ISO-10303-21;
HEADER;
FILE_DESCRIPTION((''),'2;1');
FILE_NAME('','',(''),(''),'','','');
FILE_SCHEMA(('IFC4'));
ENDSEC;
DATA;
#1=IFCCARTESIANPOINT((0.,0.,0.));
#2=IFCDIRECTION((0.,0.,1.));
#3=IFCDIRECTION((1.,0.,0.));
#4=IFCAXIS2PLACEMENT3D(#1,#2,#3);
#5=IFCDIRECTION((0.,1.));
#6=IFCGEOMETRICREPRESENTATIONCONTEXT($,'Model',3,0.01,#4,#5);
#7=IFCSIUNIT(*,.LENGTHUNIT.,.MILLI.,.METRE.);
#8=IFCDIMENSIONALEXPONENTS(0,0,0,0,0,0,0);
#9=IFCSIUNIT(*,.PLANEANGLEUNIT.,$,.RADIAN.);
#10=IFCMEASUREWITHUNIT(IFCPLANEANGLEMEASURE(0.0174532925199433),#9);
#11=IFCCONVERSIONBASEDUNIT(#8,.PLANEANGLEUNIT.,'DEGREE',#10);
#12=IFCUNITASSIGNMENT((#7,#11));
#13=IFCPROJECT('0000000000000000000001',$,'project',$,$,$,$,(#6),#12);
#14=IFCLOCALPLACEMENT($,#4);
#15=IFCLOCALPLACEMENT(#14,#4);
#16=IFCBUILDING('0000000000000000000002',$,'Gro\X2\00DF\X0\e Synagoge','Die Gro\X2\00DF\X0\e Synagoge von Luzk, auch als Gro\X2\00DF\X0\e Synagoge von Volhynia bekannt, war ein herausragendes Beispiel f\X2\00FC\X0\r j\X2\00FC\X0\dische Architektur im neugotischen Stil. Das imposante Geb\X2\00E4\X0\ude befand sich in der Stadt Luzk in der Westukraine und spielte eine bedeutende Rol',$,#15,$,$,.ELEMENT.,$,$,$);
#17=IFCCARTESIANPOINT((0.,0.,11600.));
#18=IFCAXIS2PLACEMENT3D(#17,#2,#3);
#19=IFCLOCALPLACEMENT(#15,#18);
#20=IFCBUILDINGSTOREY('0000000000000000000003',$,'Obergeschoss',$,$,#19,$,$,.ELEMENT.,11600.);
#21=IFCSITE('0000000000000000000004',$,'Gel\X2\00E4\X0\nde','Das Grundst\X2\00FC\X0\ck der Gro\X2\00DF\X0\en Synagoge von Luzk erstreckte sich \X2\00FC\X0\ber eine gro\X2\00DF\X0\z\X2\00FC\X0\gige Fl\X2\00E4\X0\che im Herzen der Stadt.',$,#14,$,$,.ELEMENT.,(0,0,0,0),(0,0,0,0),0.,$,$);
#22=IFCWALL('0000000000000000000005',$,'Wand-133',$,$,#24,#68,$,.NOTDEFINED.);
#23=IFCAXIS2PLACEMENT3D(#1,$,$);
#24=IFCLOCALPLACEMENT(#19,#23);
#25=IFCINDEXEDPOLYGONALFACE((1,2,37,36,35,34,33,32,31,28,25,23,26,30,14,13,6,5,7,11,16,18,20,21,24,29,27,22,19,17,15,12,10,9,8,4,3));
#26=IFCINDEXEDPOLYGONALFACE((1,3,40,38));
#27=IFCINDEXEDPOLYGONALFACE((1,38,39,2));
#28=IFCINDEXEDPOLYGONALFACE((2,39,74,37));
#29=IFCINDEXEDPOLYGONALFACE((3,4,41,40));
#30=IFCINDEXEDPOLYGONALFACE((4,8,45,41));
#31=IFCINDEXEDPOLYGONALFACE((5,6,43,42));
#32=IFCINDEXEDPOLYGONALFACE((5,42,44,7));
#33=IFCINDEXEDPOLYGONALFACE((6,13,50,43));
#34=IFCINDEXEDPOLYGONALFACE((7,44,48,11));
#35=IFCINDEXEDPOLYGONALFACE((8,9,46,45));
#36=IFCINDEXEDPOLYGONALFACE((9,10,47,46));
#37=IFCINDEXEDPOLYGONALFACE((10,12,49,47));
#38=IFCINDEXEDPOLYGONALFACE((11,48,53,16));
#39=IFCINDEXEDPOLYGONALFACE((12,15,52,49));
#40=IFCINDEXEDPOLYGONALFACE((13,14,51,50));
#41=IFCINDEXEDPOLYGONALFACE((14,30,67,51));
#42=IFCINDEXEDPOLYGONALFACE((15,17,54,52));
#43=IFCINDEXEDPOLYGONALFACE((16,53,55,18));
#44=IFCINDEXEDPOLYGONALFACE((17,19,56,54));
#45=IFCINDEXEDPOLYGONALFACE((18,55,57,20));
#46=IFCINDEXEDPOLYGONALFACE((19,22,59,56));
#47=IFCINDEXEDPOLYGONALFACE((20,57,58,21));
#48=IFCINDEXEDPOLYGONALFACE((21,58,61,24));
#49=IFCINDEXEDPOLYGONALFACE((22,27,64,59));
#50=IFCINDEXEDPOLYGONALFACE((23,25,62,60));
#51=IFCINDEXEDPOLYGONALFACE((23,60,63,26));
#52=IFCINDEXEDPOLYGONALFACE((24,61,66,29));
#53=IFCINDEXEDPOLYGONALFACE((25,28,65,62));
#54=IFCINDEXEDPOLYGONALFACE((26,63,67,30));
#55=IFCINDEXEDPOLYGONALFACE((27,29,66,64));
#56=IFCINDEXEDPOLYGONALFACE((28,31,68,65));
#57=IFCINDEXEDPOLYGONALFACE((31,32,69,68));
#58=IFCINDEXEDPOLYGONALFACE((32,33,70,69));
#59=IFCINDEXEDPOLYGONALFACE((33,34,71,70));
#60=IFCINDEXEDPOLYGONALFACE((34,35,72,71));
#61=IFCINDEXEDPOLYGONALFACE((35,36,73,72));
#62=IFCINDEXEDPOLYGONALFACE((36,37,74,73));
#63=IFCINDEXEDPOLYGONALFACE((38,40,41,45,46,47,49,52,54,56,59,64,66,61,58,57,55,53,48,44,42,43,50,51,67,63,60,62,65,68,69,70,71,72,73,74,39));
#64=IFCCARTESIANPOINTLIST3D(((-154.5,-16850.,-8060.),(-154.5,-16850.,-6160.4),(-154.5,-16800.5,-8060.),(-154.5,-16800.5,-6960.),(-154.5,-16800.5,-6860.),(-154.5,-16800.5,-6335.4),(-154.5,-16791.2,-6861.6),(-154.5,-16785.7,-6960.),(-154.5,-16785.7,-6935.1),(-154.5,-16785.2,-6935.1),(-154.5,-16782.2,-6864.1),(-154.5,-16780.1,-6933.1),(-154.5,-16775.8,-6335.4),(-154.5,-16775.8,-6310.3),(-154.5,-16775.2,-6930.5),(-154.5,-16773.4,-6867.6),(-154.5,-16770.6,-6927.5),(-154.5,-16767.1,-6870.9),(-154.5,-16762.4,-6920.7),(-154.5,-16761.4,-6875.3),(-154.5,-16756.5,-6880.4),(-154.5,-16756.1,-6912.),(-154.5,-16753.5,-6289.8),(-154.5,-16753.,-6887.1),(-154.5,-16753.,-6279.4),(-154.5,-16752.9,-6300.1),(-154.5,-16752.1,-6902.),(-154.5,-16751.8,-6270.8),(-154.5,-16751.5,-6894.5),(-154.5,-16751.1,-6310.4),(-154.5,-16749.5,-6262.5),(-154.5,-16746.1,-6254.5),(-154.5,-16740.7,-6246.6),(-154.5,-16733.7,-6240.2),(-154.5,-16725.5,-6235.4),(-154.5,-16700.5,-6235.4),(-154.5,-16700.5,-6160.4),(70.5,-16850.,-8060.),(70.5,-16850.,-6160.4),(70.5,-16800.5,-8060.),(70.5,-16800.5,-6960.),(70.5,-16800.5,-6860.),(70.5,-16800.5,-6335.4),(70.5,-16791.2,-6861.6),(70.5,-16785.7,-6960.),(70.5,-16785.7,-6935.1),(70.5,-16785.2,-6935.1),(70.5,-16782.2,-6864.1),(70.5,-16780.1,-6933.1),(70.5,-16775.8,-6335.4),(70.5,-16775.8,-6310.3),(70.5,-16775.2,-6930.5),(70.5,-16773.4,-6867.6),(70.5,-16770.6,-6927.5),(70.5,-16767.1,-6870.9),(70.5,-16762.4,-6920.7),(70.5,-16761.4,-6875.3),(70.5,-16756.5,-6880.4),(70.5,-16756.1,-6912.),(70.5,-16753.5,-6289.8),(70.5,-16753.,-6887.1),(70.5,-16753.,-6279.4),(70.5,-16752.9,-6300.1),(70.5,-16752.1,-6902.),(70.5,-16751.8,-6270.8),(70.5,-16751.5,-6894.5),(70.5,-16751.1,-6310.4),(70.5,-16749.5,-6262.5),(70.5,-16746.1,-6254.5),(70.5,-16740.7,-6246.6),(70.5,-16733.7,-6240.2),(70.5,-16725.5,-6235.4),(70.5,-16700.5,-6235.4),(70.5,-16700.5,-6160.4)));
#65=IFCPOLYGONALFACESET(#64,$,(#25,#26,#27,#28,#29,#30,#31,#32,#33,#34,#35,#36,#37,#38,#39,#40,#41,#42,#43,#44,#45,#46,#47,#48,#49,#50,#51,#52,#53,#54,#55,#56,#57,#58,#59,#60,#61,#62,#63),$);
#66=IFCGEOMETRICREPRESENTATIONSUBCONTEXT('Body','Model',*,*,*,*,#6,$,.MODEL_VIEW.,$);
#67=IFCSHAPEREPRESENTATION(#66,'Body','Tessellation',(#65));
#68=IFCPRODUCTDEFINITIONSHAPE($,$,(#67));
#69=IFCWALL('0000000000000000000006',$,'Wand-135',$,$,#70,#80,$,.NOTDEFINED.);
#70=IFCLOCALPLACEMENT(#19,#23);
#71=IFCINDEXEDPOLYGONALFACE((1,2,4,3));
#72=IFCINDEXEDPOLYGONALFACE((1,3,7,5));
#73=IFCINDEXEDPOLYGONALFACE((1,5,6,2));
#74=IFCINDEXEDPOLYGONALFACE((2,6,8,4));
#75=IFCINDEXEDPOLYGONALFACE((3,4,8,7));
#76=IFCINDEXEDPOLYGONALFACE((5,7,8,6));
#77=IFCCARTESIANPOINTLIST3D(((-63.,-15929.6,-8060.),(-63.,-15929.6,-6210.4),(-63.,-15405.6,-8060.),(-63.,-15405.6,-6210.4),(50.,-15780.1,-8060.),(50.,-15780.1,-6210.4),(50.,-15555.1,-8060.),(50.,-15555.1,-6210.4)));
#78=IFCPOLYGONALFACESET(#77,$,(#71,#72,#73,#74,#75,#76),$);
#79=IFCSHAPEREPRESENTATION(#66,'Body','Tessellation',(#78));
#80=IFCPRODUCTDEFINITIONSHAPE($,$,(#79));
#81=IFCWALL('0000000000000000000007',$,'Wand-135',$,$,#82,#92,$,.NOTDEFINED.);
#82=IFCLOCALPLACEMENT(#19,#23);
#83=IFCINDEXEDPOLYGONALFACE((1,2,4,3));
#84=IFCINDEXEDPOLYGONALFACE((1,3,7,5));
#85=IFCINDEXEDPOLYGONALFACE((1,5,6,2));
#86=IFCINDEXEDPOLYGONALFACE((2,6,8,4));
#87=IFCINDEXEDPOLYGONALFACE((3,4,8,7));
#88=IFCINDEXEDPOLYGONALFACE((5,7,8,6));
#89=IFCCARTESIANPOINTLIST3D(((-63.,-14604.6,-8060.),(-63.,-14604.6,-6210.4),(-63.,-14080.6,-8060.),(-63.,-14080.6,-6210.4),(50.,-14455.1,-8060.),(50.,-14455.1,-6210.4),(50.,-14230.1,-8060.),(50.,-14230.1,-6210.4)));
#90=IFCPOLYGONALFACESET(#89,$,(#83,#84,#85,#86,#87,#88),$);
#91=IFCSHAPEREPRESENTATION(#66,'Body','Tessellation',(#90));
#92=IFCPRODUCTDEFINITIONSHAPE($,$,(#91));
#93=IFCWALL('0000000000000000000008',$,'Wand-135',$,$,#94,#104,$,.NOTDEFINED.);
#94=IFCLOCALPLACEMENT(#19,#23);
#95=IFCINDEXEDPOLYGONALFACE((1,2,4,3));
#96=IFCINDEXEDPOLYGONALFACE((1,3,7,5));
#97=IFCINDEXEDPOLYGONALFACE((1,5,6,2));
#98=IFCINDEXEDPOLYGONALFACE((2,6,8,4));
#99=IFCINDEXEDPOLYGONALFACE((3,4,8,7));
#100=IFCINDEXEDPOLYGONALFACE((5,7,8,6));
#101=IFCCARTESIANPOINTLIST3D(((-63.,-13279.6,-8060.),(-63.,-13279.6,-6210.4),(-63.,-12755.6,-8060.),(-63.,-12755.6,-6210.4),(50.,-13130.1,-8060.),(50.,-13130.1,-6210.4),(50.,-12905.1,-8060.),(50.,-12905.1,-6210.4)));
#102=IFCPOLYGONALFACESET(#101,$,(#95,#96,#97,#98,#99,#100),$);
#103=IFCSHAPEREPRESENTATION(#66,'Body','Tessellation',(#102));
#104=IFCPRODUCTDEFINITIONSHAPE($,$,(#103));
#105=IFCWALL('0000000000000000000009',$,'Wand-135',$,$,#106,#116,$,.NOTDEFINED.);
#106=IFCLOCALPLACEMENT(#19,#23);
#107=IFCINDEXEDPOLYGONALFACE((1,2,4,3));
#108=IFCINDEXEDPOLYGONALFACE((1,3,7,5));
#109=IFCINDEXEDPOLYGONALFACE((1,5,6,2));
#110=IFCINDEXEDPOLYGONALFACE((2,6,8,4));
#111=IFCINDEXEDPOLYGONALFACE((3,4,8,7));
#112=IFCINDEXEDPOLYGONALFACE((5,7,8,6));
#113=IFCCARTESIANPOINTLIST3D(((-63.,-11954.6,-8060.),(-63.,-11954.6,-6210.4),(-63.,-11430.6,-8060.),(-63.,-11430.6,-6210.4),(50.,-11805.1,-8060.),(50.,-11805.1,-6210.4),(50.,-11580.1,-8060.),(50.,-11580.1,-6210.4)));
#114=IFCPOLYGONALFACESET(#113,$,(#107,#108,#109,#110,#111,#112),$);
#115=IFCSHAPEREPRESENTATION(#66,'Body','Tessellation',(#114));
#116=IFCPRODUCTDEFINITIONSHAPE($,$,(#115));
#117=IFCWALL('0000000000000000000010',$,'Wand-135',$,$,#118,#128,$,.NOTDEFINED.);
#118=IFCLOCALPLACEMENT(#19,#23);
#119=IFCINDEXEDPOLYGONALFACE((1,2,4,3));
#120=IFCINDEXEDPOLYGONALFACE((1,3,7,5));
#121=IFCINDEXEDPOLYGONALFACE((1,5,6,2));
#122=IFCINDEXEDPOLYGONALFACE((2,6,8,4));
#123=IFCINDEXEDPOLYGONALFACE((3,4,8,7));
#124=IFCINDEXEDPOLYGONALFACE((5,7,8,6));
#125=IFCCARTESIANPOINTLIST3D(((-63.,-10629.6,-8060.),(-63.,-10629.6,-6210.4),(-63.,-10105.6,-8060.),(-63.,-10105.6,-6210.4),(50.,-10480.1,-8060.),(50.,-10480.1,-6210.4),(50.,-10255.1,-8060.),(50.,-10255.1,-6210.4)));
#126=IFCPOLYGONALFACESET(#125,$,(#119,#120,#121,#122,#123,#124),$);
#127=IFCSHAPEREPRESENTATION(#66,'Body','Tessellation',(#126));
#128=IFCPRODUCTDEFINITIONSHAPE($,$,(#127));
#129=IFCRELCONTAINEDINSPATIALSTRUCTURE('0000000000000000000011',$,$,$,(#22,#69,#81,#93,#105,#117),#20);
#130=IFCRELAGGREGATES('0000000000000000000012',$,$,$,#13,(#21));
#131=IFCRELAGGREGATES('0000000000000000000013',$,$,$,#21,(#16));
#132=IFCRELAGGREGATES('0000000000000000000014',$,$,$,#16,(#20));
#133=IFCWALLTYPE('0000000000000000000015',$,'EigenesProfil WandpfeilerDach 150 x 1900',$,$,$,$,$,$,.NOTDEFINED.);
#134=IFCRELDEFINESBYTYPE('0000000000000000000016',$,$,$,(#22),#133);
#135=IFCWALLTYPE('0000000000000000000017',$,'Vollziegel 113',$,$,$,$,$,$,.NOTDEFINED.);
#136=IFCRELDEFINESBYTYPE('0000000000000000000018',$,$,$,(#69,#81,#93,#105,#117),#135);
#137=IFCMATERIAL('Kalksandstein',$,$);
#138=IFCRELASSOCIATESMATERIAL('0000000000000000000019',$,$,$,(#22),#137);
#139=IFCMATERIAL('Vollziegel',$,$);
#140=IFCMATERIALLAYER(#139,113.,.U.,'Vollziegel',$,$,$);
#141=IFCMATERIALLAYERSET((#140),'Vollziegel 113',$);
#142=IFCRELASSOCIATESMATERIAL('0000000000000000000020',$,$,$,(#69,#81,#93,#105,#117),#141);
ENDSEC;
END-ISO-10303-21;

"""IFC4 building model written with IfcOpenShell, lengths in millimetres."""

from ifc_helpers import new_model, entity, si_unit, converted_unit, direction, frame, origin_with_axes, place, context, subcontext, project, spatial, line, arc, indexed_curve, outline, extrude, material, layer, layer_set, layer_usage, material_profile, profile_set, type_object, element, save


model = new_model("IFC4")

# Units and contexts
model_context = context("Model", 3, precision=0.01, world=origin_with_axes(), true_north=direction((0.0, 1.0)))
body_context = subcontext(model_context, "Body", "Model", "MODEL_VIEW")
ifc_project = project(units=[si_unit("LENGTHUNIT", "METRE", prefix="MILLI"), converted_unit("PLANEANGLEUNIT", "DEGREE", entity("IfcPlaneAngleMeasure", 0.0174532925199433), si_unit("PLANEANGLEUNIT", "RADIAN"), dimensions=[0, 0, 0, 0, 0, 0, 0])], contexts=[model_context])

# Site, building, storey
site_placement = place(None, origin_with_axes())
site = spatial("IfcSite", under=ifc_project, at=site_placement, Name="Gelände", Description="Das Grundstück der Großen Synagoge von Luzk erstreckte sich über eine großzügige Fläche im Herzen der Stadt.", CompositionType="ELEMENT", RefLatitude=(0, 0, 0, 0), RefLongitude=(0, 0, 0, 0), RefElevation=0.0)
building_placement = place(site_placement, origin_with_axes())
building = spatial("IfcBuilding", under=site, at=building_placement, Name="Große Synagoge", Description="Die Große Synagoge von Luzk, auch als Große Synagoge von Volhynia bekannt, war ein herausragendes Beispiel für jüdische Architektur im neugotischen Stil. Das imposante Gebäude befand sich in der Stadt Luzk in der Westukraine und spielte eine bedeutende Rol", CompositionType="ELEMENT")
storey_placement = place(building_placement, frame((0.0, 0.0, 11600.0), z_axis=(0.0, 0.0, 1.0), x_axis=(1.0, 0.0, 0.0)))
storey = spatial("IfcBuildingStorey", under=building, at=storey_placement, Name="Obergeschoss", CompositionType="ELEMENT", Elevation=11600.0)

# Walls
ifc_material_1 = material(Name="Kalksandstein")
ifc_material_profile = material_profile(ifc_material_1, outline(indexed_curve([(74.2, 1749.6), (98.9, 1749.6), (96.7, 1765.0), (97.0, 1780.5), (99.2, 1793.4), (103.9, 1805.5), (112.6, 1816.7), (124.5, 1824.6), (149.5, 1824.6), (149.5, 1899.6), (0.0, 1899.6), (0.0, 0.0), (49.5, 0.0), (49.5, 1100.0), (64.3, 1100.0), (64.3, 1124.9), (64.8, 1124.9), (72.4, 1128.1), (79.4, 1132.4), (91.1, 1143.4), (97.9, 1157.9), (98.0, 1169.2), (93.5, 1179.5), (85.8, 1187.0), (76.6, 1192.3), (63.3, 1197.2), (49.5, 1200.0), (49.5, 1724.6), (74.2, 1724.6)], segments=[line(1, 2), arc(2, 3, 4), arc(4, 5, 6), arc(6, 7, 8), line(8, 9, 10, 11, 12, 13, 14, 15, 16, 17), arc(17, 18, 19), arc(19, 20, 21), arc(21, 22, 23), arc(23, 24, 25), arc(25, 26, 27), line(27, 28, 29, 1)])), Name="Kalksandstein")
ifc_profile_set = profile_set([ifc_material_profile], Name="EigenesProfil WandpfeilerDach")
wall_type_1 = type_object("IfcWallType", Name="EigenesProfil WandpfeilerDach 150 x 1900", PredefinedType="NOTDEFINED")
wall_1_placement = place(storey_placement, frame((-154.5, -16850.0, -8060.0), z_axis=(0.0, 0.0, 1.0), x_axis=(1.0, 0.0, 0.0)))
element("IfcWall", 1, at=wall_1_placement, inside=storey, type_object=wall_type_1, material=ifc_profile_set, Name="Wand-133", PredefinedType="NOTDEFINED", context=body_context, shape_type="SweptSolid", body=[
    extrude(outline(indexed_curve([(74.2, 1749.6), (98.9, 1749.6), (96.7, 1765.0), (97.0, 1780.5), (99.2, 1793.4), (103.9, 1805.5), (112.6, 1816.7), (124.5, 1824.6), (149.5, 1824.6), (149.5, 1899.6), (0.0, 1899.6), (0.0, 0.0), (49.5, 0.0), (49.5, 1100.0), (64.3, 1100.0), (64.3, 1124.9), (64.8, 1124.9), (72.4, 1128.1), (79.4, 1132.4), (91.1, 1143.4), (97.9, 1157.9), (98.0, 1169.2), (93.5, 1179.5), (85.8, 1187.0), (76.6, 1192.3), (63.3, 1197.2), (49.5, 1200.0), (49.5, 1724.6), (74.2, 1724.6)], segments=[line(1, 2), arc(2, 3, 4), arc(4, 5, 6), arc(6, 7, 8), line(8, 9, 10, 11, 12, 13, 14, 15, 16, 17), arc(17, 18, 19), arc(19, 20, 21), arc(21, 22, 23), arc(23, 24, 25), arc(25, 26, 27), line(27, 28, 29, 1)])), frame((0.0, 0.0, 0.0), z_axis=(1.0, 0.0, 0.0), x_axis=(0.0, 1.0, 0.0)), (0.0, 0.0, 1.0), 225.0),
])
ifc_material_2 = material(Name="Vollziegel")
ifc_layer = layer(ifc_material_2, 113.0, ventilated="UNKNOWN", Name="Vollziegel")
ifc_layer_set = layer_set([ifc_layer], Name="Vollziegel 113")
ifc_layer_usage_1 = layer_usage(ifc_layer_set, "AXIS2", "NEGATIVE", 113.0)
wall_type_2 = type_object("IfcWallType", Name="Vollziegel 113", PredefinedType="NOTDEFINED")
wall_2_placement = place(storey_placement, frame((-63.0, -15555.1, -8060.0), z_axis=(0.0, 0.0, 1.0), x_axis=(0.0, -1.0, 0.0)))
element("IfcWall", 2, at=wall_2_placement, inside=storey, type_object=wall_type_2, material=ifc_layer_usage_1, Name="Wand-135", PredefinedType="NOTDEFINED", context=body_context, shape_type="SweptSolid", body=[
    extrude(outline(indexed_curve([(-149.5, 0.0), (374.5, 0.0), (225.0, 113.0), (0.0, 113.0)], segments=[line(1, 2, 3, 4, 1)])), origin_with_axes(), (0.0, 0.0, 1.0), 1849.6),
])
ifc_layer_usage_2 = layer_usage(ifc_layer_set, "AXIS2", "NEGATIVE", 113.0)
wall_3_placement = place(storey_placement, frame((-63.0, -14230.1, -8060.0), z_axis=(0.0, 0.0, 1.0), x_axis=(0.0, -1.0, 0.0)))
element("IfcWall", 3, at=wall_3_placement, inside=storey, type_object=wall_type_2, material=ifc_layer_usage_2, Name="Wand-135", PredefinedType="NOTDEFINED", context=body_context, shape_type="SweptSolid", body=[
    extrude(outline(indexed_curve([(-149.5, 0.0), (374.5, 0.0), (225.0, 113.0), (0.0, 113.0)], segments=[line(1, 2, 3, 4, 1)])), origin_with_axes(), (0.0, 0.0, 1.0), 1849.6),
])
ifc_layer_usage_3 = layer_usage(ifc_layer_set, "AXIS2", "NEGATIVE", 113.0)
wall_4_placement = place(storey_placement, frame((-63.0, -12905.1, -8060.0), z_axis=(0.0, 0.0, 1.0), x_axis=(0.0, -1.0, 0.0)))
element("IfcWall", 4, at=wall_4_placement, inside=storey, type_object=wall_type_2, material=ifc_layer_usage_3, Name="Wand-135", PredefinedType="NOTDEFINED", context=body_context, shape_type="SweptSolid", body=[
    extrude(outline(indexed_curve([(-149.5, 0.0), (374.5, 0.0), (225.0, 113.0), (0.0, 113.0)], segments=[line(1, 2, 3, 4, 1)])), origin_with_axes(), (0.0, 0.0, 1.0), 1849.6),
])
ifc_layer_usage_4 = layer_usage(ifc_layer_set, "AXIS2", "NEGATIVE", 113.0)
wall_5_placement = place(storey_placement, frame((-63.0, -11580.1, -8060.0), z_axis=(0.0, 0.0, 1.0), x_axis=(0.0, -1.0, 0.0)))
element("IfcWall", 5, at=wall_5_placement, inside=storey, type_object=wall_type_2, material=ifc_layer_usage_4, Name="Wand-135", PredefinedType="NOTDEFINED", context=body_context, shape_type="SweptSolid", body=[
    extrude(outline(indexed_curve([(-149.5, 0.0), (374.5, 0.0), (225.0, 113.0), (0.0, 113.0)], segments=[line(1, 2, 3, 4, 1)])), origin_with_axes(), (0.0, 0.0, 1.0), 1849.6),
])
ifc_layer_usage_5 = layer_usage(ifc_layer_set, "AXIS2", "NEGATIVE", 113.0)
wall_6_placement = place(storey_placement, frame((-63.0, -10255.1, -8060.0), z_axis=(0.0, 0.0, 1.0), x_axis=(0.0, -1.0, 0.0)))
element("IfcWall", 6, at=wall_6_placement, inside=storey, type_object=wall_type_2, material=ifc_layer_usage_5, Name="Wand-135", PredefinedType="NOTDEFINED", context=body_context, shape_type="SweptSolid", body=[
    extrude(outline(indexed_curve([(-149.5, 0.0), (374.5, 0.0), (225.0, 113.0), (0.0, 113.0)], segments=[line(1, 2, 3, 4, 1)])), origin_with_axes(), (0.0, 0.0, 1.0), 1849.6),
])

save(model, "model.ifc")
